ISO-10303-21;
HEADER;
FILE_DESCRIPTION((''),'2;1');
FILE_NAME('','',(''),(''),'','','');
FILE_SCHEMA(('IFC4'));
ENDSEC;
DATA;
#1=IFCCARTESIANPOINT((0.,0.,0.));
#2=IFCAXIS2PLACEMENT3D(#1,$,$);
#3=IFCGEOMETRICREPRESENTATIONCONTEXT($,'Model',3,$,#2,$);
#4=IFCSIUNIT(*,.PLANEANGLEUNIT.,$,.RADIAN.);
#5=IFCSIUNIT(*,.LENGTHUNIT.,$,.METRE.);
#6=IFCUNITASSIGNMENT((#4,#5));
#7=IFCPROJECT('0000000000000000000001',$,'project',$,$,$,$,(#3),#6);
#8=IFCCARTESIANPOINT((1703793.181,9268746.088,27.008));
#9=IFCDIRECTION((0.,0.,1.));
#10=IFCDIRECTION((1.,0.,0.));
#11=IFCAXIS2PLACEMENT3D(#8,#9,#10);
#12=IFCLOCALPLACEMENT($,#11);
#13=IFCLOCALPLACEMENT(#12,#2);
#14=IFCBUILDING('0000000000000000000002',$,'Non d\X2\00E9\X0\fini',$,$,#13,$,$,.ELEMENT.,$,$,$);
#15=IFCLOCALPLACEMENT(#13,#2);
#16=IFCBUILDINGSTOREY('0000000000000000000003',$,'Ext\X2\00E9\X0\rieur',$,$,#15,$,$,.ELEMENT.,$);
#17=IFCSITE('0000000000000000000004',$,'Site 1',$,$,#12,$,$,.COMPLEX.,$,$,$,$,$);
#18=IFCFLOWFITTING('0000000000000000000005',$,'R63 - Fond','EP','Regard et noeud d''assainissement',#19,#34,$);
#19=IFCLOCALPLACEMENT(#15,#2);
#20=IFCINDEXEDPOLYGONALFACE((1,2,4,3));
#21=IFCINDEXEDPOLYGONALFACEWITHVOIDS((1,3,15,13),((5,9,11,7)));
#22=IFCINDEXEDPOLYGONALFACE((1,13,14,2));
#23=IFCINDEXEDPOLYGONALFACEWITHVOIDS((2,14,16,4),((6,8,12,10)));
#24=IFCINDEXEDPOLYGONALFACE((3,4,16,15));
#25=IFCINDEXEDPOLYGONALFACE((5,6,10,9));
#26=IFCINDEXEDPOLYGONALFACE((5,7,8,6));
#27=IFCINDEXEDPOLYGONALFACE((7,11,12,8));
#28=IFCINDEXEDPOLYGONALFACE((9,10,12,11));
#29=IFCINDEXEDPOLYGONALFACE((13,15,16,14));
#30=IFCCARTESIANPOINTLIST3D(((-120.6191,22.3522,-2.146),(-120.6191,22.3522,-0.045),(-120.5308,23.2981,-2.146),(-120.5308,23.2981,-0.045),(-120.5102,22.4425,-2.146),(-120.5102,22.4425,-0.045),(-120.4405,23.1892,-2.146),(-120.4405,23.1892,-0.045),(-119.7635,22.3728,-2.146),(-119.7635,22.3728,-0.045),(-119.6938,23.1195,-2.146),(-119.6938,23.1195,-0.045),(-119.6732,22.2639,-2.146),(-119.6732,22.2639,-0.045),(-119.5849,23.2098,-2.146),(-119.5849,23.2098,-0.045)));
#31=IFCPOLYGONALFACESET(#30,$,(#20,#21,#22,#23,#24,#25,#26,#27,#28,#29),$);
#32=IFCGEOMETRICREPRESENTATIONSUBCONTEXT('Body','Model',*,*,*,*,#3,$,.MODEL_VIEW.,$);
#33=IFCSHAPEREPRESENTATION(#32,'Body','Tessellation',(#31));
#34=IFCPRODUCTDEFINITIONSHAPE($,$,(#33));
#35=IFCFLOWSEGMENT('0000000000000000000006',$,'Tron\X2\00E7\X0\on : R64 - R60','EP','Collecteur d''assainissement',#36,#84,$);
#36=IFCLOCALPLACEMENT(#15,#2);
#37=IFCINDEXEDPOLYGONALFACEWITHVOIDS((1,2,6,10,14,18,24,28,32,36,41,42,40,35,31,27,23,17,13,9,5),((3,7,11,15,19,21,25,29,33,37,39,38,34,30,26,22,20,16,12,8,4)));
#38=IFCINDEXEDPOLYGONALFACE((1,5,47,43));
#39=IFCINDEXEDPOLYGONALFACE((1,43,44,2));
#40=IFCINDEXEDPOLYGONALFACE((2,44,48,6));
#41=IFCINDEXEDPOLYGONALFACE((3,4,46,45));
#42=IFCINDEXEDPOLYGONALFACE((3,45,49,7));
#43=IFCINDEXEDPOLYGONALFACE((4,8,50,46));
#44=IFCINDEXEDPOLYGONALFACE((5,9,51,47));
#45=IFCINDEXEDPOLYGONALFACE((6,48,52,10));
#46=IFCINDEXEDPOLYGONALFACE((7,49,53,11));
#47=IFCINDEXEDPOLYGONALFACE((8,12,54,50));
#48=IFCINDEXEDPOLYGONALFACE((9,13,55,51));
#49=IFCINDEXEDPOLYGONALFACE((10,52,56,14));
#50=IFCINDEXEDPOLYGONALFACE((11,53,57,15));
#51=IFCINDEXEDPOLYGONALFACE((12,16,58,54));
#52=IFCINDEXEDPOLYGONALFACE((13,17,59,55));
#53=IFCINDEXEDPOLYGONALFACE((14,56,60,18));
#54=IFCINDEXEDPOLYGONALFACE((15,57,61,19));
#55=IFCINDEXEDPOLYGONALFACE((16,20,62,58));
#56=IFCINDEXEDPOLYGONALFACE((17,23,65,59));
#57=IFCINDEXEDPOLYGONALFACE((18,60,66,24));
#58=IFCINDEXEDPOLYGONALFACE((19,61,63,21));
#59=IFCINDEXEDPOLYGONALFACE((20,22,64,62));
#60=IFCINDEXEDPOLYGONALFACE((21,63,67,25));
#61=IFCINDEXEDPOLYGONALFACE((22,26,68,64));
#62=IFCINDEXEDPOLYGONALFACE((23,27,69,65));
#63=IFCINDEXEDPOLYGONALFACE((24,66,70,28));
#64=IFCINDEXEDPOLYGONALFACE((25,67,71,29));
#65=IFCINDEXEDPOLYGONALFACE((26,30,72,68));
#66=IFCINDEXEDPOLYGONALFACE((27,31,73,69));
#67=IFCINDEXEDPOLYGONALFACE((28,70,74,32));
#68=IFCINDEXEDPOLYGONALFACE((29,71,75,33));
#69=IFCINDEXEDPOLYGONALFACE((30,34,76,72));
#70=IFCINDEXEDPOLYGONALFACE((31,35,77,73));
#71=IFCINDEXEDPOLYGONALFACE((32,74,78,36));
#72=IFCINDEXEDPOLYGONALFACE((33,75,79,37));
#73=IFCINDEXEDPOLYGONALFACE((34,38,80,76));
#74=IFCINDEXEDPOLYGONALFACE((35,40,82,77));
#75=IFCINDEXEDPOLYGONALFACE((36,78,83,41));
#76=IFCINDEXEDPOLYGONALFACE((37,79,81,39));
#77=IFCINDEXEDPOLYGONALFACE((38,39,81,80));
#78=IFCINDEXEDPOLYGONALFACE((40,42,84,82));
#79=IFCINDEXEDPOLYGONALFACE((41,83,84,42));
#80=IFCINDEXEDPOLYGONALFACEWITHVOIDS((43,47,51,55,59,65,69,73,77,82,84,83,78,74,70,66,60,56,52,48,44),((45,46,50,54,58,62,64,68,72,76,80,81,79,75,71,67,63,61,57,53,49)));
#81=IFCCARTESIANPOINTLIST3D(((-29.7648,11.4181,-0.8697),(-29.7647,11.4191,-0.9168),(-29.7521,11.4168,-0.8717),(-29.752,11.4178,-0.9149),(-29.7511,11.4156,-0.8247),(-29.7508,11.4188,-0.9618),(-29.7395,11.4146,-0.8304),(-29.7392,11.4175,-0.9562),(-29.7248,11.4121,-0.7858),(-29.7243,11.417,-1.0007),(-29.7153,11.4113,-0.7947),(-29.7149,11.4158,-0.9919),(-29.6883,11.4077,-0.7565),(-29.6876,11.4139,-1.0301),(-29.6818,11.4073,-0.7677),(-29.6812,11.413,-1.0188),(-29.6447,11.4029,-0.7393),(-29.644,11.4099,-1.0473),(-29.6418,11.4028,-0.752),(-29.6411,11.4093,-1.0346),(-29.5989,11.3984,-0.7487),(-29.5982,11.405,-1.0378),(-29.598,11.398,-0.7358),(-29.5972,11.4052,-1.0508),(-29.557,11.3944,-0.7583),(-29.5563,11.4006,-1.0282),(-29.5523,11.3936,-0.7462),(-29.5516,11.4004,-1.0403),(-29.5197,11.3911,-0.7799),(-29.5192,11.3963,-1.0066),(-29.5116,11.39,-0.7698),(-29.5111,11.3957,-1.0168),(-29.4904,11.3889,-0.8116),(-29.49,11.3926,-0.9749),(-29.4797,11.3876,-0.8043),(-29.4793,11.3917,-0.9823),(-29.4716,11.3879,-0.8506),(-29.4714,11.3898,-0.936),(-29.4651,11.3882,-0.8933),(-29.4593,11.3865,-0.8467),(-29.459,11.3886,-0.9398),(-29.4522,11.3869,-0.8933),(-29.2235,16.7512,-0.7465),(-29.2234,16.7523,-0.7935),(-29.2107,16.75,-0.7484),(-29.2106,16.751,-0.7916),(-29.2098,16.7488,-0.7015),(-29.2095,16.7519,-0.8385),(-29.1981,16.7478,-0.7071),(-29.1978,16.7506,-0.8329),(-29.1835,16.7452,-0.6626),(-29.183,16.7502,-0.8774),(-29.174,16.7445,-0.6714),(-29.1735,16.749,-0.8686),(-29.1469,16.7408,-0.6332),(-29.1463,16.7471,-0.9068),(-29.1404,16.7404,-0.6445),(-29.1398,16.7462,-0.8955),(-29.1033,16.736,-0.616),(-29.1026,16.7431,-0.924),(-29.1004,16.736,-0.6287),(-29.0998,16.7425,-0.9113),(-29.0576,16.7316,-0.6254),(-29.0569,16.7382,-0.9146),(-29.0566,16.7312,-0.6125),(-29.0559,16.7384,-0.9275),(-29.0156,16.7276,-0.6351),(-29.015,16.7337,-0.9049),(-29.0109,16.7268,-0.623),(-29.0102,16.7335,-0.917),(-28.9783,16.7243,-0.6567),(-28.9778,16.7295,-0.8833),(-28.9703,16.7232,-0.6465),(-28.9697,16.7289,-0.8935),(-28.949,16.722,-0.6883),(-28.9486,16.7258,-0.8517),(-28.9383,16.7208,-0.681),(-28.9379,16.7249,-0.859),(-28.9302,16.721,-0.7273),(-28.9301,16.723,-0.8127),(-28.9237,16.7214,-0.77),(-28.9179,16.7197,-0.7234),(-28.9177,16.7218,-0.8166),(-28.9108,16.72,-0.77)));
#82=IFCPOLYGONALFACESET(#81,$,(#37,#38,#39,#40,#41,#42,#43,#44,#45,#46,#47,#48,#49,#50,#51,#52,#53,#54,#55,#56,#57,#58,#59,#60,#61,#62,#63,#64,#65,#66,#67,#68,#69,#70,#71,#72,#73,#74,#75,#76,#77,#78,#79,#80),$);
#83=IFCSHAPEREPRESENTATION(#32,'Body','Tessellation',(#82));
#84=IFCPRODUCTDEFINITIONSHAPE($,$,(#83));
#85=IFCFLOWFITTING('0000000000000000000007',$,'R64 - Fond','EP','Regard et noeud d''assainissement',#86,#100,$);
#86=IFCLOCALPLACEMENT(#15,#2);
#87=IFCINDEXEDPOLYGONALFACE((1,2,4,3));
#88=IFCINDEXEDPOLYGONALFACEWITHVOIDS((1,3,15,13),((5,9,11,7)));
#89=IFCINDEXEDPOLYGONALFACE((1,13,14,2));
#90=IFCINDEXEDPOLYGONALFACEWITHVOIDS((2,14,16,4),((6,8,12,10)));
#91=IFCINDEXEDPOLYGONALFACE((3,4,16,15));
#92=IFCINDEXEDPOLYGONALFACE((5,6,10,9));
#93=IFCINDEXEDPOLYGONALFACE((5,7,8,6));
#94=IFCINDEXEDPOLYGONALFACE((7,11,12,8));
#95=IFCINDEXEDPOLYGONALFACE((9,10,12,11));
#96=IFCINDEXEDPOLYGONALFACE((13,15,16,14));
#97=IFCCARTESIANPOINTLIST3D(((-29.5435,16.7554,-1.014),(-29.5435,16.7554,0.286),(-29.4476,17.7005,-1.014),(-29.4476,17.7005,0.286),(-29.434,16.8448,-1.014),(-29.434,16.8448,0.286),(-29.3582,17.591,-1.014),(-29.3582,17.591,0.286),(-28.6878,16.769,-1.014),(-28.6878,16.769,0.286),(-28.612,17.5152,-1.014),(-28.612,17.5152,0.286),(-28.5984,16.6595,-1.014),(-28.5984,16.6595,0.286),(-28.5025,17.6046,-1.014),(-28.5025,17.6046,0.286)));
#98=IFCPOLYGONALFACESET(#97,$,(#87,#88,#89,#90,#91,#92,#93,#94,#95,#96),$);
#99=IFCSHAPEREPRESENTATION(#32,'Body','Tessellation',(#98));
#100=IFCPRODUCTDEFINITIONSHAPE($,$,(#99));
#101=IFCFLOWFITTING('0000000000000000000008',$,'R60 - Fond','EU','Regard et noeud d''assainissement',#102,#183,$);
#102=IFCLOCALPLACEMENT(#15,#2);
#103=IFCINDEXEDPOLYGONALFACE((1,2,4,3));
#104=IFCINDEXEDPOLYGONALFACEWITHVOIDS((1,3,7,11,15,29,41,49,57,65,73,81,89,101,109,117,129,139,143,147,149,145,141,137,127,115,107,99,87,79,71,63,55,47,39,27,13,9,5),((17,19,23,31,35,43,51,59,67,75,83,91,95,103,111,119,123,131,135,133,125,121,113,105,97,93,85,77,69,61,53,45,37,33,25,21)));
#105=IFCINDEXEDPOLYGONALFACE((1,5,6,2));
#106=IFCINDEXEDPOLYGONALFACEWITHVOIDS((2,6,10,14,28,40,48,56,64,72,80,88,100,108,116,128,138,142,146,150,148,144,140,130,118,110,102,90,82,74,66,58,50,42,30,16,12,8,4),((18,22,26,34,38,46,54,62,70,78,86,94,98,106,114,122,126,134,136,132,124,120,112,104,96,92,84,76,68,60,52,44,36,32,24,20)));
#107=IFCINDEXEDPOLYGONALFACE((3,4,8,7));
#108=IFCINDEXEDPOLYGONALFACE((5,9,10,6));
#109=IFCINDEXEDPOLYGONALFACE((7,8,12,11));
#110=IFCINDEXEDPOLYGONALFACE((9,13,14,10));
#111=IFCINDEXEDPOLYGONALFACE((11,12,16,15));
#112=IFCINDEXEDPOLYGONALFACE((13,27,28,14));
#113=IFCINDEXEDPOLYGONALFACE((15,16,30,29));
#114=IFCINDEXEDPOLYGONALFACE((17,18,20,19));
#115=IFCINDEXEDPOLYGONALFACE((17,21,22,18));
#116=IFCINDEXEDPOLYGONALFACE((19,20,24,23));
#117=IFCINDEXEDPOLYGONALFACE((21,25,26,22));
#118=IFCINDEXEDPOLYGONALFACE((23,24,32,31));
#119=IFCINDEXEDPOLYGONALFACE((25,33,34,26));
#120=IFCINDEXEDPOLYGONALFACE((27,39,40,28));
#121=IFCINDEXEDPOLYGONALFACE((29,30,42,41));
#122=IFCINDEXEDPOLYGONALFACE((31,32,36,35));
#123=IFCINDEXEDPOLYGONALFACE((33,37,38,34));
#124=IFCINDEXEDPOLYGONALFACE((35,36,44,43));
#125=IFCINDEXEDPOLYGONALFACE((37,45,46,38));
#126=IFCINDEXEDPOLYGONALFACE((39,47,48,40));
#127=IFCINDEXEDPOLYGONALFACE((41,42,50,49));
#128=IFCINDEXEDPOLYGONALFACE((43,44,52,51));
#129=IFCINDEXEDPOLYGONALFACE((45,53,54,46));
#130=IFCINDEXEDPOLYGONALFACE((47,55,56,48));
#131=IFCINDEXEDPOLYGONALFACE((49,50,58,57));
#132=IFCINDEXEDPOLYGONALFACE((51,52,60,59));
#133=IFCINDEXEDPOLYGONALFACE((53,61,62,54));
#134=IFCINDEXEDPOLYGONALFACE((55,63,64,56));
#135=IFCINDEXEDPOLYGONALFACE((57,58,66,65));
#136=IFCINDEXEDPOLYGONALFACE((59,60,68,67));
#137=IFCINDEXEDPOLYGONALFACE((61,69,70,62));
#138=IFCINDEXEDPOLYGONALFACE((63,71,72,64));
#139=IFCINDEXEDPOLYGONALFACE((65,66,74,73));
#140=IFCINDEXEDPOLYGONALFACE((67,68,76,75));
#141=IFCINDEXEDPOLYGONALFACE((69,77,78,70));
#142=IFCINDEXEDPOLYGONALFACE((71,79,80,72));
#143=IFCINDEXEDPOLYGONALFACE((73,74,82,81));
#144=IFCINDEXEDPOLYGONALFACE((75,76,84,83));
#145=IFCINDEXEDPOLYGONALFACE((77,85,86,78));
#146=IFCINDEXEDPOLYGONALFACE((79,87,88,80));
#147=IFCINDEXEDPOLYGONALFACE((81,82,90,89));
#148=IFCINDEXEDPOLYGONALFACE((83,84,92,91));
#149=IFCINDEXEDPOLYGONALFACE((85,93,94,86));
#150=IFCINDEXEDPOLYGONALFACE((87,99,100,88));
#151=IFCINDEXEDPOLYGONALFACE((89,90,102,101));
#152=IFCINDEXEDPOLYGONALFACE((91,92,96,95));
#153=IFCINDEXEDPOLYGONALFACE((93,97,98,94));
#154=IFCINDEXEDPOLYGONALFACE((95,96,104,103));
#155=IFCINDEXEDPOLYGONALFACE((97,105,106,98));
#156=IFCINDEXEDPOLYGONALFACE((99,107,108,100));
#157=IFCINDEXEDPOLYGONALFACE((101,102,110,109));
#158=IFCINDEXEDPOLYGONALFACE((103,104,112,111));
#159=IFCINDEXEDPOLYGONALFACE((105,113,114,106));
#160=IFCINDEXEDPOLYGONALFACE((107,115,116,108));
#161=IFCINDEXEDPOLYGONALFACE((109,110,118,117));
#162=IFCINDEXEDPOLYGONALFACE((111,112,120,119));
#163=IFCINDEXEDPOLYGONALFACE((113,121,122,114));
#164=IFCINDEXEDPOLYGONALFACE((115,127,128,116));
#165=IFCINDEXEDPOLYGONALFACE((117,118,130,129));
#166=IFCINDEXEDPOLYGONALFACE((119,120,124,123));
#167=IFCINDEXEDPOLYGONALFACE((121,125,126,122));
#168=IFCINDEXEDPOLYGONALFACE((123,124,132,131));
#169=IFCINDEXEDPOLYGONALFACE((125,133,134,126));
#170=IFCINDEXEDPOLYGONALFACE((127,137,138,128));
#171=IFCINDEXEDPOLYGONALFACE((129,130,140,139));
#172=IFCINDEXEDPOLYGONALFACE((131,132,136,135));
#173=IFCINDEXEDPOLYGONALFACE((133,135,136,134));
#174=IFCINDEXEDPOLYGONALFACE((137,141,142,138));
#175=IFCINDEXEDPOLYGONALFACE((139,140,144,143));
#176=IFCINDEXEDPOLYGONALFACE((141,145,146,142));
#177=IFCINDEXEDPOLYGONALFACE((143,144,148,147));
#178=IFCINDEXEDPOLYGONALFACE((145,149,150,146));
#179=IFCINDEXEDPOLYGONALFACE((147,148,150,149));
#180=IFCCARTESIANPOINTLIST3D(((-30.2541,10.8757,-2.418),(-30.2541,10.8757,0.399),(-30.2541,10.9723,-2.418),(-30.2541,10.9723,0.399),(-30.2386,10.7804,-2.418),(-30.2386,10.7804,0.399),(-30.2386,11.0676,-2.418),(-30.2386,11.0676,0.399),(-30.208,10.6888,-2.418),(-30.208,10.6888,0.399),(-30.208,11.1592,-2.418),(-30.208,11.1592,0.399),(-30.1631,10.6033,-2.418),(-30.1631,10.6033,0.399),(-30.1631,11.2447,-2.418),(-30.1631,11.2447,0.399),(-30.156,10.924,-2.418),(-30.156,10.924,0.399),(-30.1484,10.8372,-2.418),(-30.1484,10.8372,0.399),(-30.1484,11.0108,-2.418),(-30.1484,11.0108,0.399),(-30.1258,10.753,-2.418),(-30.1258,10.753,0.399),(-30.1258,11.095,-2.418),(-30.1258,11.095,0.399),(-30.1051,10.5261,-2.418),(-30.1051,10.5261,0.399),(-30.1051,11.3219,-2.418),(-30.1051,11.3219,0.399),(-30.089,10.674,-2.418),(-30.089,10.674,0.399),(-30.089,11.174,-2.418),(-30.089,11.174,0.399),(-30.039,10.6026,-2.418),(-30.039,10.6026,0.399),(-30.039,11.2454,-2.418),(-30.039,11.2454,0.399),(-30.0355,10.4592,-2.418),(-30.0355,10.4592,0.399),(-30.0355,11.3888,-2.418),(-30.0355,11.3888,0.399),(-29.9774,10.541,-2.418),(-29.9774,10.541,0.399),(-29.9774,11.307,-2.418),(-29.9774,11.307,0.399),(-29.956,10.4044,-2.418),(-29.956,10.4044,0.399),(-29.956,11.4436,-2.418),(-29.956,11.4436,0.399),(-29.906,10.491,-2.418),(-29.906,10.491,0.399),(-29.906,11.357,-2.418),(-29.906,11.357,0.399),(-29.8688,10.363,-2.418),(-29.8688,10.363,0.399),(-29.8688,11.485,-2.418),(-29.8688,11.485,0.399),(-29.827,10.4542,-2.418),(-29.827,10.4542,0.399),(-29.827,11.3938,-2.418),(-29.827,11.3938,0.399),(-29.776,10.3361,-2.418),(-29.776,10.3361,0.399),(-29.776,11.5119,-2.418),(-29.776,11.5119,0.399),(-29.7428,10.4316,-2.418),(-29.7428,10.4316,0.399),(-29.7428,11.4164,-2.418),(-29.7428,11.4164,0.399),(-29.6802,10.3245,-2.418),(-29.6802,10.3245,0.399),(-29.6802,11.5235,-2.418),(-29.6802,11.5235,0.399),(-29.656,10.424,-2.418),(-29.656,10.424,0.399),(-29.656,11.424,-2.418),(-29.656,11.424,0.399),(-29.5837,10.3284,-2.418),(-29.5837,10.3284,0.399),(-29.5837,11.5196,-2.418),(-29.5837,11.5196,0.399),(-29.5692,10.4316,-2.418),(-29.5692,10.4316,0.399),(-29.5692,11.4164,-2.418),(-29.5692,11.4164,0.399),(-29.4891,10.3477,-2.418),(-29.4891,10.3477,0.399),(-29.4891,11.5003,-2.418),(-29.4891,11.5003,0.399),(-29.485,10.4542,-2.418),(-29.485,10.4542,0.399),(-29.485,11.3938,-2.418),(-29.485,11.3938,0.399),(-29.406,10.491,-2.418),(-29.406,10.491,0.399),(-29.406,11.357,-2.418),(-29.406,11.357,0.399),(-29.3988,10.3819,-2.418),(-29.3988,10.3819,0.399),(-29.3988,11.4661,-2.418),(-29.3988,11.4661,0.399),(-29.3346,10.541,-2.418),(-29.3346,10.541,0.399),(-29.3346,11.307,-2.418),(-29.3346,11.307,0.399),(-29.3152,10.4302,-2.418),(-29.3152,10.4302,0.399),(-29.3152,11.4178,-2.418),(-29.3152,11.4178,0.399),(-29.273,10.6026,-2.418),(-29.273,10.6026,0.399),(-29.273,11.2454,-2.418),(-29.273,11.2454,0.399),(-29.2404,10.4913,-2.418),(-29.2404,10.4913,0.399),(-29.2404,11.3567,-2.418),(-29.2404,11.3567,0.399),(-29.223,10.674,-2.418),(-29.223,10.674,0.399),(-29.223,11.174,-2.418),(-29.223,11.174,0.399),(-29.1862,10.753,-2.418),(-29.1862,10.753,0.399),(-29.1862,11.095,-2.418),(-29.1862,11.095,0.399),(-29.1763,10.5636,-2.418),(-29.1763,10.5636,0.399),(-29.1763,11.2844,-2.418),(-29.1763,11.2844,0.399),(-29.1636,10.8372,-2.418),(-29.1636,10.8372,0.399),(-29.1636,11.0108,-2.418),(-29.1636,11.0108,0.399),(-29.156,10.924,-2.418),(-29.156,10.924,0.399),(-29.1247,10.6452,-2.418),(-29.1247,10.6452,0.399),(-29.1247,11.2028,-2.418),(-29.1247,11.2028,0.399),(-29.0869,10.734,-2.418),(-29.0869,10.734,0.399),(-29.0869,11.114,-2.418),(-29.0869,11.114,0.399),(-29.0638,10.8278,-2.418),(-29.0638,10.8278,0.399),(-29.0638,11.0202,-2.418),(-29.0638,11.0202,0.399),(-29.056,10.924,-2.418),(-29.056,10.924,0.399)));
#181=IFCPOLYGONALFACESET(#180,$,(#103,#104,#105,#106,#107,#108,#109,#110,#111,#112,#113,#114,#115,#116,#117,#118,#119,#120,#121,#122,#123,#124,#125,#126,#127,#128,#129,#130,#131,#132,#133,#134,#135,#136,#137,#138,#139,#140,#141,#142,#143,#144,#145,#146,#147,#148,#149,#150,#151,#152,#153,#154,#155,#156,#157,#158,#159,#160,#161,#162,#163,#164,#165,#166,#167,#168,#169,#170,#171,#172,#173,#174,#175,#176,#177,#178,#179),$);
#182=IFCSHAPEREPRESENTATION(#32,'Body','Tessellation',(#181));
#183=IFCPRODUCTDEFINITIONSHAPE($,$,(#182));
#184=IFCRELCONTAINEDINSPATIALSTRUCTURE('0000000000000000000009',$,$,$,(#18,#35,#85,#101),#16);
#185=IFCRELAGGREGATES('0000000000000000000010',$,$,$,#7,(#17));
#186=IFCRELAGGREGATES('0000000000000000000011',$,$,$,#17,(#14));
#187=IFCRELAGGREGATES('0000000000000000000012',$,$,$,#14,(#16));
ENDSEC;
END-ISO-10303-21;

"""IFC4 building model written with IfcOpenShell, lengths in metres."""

from ifc_helpers import new_model, si_unit, frame, origin, origin_2d, place, context, subcontext, project, spatial, hollow_rectangle, hollow_circle, extrude, element, save


model = new_model("IFC4")

# Units and contexts
model_context = context("Model", 3, world=origin())
body_context = subcontext(model_context, "Body", "Model", "MODEL_VIEW")
ifc_project = project(units=[si_unit("PLANEANGLEUNIT", "RADIAN"), si_unit("LENGTHUNIT", "METRE")], contexts=[model_context])

# Site, building, storey
site_placement = place(None, frame((1703793.181, 9268746.088, 27.008), z_axis=(0.0, 0.0, 1.0), x_axis=(1.0, 0.0, 0.0)))
site = spatial("IfcSite", under=ifc_project, at=site_placement, Name="Site 1", CompositionType="COMPLEX")
building_placement = place(site_placement, origin())
building = spatial("IfcBuilding", under=site, at=building_placement, Name="Non défini", CompositionType="ELEMENT")
storey_placement = place(building_placement, origin())
storey = spatial("IfcBuildingStorey", under=building, at=storey_placement, Name="Extérieur", CompositionType="ELEMENT")

# Flow fitting
flow_fitting_1_placement = place(storey_placement, origin())
element("IfcFlowFitting", 1, at=flow_fitting_1_placement, inside=storey, Name="R63 - Fond", Description="EP", ObjectType="Regard et noeud d'assainissement", context=body_context, shape_type="SweptSolid", body=[
    extrude(hollow_rectangle(XDim=0.95, YDim=0.95, WallThickness=0.1, at=origin_2d()), frame((-120.102, 22.781, -2.146), z_axis=(0.0, 0.0, 1.0), x_axis=(0.093, 0.996, 0.0)), (0.0, 0.0, 1.0), 2.101),
])

# Flow segment
flow_segment_1_placement = place(storey_placement, origin())
element("IfcFlowSegment", 2, at=flow_segment_1_placement, inside=storey, Name="Tronçon : R64 - R60", Description="EP", ObjectType="Collecteur d'assainissement", context=body_context, shape_type="SweptSolid", body=[
    extrude(hollow_circle(Radius=0.158, WallThickness=0.013, at=origin_2d()), frame((-29.068, 16.736, -0.77), z_axis=(-0.101, -0.995, -0.023), x_axis=(0.995, -0.101, 0.0)), (0.0, 0.0, 1.0), 5.362),
])

# Flow fittings
flow_fitting_2_placement = place(storey_placement, origin())
element("IfcFlowFitting", 3, at=flow_fitting_2_placement, inside=storey, Name="R64 - Fond", Description="EP", ObjectType="Regard et noeud d'assainissement", context=body_context, shape_type="SweptSolid", body=[
    extrude(hollow_rectangle(XDim=0.95, YDim=0.95, WallThickness=0.1, at=origin_2d()), frame((-29.023, 17.18, -1.014), z_axis=(0.0, 0.0, 1.0), x_axis=(0.101, 0.995, 0.0)), (0.0, 0.0, 1.0), 1.3),
])
flow_fitting_3_placement = place(storey_placement, origin())
element("IfcFlowFitting", 4, at=flow_fitting_3_placement, inside=storey, Name="R60 - Fond", Description="EU", ObjectType="Regard et noeud d'assainissement", context=body_context, shape_type="SweptSolid", body=[
    extrude(hollow_circle(Radius=0.6, WallThickness=0.1, at=origin_2d()), frame((-29.656, 10.924, -2.418), z_axis=(0.0, 0.0, 1.0), x_axis=(1.0, 0.0, 0.0)), (0.0, 0.0, 1.0), 2.817),
])

save(model, "model.ifc")
